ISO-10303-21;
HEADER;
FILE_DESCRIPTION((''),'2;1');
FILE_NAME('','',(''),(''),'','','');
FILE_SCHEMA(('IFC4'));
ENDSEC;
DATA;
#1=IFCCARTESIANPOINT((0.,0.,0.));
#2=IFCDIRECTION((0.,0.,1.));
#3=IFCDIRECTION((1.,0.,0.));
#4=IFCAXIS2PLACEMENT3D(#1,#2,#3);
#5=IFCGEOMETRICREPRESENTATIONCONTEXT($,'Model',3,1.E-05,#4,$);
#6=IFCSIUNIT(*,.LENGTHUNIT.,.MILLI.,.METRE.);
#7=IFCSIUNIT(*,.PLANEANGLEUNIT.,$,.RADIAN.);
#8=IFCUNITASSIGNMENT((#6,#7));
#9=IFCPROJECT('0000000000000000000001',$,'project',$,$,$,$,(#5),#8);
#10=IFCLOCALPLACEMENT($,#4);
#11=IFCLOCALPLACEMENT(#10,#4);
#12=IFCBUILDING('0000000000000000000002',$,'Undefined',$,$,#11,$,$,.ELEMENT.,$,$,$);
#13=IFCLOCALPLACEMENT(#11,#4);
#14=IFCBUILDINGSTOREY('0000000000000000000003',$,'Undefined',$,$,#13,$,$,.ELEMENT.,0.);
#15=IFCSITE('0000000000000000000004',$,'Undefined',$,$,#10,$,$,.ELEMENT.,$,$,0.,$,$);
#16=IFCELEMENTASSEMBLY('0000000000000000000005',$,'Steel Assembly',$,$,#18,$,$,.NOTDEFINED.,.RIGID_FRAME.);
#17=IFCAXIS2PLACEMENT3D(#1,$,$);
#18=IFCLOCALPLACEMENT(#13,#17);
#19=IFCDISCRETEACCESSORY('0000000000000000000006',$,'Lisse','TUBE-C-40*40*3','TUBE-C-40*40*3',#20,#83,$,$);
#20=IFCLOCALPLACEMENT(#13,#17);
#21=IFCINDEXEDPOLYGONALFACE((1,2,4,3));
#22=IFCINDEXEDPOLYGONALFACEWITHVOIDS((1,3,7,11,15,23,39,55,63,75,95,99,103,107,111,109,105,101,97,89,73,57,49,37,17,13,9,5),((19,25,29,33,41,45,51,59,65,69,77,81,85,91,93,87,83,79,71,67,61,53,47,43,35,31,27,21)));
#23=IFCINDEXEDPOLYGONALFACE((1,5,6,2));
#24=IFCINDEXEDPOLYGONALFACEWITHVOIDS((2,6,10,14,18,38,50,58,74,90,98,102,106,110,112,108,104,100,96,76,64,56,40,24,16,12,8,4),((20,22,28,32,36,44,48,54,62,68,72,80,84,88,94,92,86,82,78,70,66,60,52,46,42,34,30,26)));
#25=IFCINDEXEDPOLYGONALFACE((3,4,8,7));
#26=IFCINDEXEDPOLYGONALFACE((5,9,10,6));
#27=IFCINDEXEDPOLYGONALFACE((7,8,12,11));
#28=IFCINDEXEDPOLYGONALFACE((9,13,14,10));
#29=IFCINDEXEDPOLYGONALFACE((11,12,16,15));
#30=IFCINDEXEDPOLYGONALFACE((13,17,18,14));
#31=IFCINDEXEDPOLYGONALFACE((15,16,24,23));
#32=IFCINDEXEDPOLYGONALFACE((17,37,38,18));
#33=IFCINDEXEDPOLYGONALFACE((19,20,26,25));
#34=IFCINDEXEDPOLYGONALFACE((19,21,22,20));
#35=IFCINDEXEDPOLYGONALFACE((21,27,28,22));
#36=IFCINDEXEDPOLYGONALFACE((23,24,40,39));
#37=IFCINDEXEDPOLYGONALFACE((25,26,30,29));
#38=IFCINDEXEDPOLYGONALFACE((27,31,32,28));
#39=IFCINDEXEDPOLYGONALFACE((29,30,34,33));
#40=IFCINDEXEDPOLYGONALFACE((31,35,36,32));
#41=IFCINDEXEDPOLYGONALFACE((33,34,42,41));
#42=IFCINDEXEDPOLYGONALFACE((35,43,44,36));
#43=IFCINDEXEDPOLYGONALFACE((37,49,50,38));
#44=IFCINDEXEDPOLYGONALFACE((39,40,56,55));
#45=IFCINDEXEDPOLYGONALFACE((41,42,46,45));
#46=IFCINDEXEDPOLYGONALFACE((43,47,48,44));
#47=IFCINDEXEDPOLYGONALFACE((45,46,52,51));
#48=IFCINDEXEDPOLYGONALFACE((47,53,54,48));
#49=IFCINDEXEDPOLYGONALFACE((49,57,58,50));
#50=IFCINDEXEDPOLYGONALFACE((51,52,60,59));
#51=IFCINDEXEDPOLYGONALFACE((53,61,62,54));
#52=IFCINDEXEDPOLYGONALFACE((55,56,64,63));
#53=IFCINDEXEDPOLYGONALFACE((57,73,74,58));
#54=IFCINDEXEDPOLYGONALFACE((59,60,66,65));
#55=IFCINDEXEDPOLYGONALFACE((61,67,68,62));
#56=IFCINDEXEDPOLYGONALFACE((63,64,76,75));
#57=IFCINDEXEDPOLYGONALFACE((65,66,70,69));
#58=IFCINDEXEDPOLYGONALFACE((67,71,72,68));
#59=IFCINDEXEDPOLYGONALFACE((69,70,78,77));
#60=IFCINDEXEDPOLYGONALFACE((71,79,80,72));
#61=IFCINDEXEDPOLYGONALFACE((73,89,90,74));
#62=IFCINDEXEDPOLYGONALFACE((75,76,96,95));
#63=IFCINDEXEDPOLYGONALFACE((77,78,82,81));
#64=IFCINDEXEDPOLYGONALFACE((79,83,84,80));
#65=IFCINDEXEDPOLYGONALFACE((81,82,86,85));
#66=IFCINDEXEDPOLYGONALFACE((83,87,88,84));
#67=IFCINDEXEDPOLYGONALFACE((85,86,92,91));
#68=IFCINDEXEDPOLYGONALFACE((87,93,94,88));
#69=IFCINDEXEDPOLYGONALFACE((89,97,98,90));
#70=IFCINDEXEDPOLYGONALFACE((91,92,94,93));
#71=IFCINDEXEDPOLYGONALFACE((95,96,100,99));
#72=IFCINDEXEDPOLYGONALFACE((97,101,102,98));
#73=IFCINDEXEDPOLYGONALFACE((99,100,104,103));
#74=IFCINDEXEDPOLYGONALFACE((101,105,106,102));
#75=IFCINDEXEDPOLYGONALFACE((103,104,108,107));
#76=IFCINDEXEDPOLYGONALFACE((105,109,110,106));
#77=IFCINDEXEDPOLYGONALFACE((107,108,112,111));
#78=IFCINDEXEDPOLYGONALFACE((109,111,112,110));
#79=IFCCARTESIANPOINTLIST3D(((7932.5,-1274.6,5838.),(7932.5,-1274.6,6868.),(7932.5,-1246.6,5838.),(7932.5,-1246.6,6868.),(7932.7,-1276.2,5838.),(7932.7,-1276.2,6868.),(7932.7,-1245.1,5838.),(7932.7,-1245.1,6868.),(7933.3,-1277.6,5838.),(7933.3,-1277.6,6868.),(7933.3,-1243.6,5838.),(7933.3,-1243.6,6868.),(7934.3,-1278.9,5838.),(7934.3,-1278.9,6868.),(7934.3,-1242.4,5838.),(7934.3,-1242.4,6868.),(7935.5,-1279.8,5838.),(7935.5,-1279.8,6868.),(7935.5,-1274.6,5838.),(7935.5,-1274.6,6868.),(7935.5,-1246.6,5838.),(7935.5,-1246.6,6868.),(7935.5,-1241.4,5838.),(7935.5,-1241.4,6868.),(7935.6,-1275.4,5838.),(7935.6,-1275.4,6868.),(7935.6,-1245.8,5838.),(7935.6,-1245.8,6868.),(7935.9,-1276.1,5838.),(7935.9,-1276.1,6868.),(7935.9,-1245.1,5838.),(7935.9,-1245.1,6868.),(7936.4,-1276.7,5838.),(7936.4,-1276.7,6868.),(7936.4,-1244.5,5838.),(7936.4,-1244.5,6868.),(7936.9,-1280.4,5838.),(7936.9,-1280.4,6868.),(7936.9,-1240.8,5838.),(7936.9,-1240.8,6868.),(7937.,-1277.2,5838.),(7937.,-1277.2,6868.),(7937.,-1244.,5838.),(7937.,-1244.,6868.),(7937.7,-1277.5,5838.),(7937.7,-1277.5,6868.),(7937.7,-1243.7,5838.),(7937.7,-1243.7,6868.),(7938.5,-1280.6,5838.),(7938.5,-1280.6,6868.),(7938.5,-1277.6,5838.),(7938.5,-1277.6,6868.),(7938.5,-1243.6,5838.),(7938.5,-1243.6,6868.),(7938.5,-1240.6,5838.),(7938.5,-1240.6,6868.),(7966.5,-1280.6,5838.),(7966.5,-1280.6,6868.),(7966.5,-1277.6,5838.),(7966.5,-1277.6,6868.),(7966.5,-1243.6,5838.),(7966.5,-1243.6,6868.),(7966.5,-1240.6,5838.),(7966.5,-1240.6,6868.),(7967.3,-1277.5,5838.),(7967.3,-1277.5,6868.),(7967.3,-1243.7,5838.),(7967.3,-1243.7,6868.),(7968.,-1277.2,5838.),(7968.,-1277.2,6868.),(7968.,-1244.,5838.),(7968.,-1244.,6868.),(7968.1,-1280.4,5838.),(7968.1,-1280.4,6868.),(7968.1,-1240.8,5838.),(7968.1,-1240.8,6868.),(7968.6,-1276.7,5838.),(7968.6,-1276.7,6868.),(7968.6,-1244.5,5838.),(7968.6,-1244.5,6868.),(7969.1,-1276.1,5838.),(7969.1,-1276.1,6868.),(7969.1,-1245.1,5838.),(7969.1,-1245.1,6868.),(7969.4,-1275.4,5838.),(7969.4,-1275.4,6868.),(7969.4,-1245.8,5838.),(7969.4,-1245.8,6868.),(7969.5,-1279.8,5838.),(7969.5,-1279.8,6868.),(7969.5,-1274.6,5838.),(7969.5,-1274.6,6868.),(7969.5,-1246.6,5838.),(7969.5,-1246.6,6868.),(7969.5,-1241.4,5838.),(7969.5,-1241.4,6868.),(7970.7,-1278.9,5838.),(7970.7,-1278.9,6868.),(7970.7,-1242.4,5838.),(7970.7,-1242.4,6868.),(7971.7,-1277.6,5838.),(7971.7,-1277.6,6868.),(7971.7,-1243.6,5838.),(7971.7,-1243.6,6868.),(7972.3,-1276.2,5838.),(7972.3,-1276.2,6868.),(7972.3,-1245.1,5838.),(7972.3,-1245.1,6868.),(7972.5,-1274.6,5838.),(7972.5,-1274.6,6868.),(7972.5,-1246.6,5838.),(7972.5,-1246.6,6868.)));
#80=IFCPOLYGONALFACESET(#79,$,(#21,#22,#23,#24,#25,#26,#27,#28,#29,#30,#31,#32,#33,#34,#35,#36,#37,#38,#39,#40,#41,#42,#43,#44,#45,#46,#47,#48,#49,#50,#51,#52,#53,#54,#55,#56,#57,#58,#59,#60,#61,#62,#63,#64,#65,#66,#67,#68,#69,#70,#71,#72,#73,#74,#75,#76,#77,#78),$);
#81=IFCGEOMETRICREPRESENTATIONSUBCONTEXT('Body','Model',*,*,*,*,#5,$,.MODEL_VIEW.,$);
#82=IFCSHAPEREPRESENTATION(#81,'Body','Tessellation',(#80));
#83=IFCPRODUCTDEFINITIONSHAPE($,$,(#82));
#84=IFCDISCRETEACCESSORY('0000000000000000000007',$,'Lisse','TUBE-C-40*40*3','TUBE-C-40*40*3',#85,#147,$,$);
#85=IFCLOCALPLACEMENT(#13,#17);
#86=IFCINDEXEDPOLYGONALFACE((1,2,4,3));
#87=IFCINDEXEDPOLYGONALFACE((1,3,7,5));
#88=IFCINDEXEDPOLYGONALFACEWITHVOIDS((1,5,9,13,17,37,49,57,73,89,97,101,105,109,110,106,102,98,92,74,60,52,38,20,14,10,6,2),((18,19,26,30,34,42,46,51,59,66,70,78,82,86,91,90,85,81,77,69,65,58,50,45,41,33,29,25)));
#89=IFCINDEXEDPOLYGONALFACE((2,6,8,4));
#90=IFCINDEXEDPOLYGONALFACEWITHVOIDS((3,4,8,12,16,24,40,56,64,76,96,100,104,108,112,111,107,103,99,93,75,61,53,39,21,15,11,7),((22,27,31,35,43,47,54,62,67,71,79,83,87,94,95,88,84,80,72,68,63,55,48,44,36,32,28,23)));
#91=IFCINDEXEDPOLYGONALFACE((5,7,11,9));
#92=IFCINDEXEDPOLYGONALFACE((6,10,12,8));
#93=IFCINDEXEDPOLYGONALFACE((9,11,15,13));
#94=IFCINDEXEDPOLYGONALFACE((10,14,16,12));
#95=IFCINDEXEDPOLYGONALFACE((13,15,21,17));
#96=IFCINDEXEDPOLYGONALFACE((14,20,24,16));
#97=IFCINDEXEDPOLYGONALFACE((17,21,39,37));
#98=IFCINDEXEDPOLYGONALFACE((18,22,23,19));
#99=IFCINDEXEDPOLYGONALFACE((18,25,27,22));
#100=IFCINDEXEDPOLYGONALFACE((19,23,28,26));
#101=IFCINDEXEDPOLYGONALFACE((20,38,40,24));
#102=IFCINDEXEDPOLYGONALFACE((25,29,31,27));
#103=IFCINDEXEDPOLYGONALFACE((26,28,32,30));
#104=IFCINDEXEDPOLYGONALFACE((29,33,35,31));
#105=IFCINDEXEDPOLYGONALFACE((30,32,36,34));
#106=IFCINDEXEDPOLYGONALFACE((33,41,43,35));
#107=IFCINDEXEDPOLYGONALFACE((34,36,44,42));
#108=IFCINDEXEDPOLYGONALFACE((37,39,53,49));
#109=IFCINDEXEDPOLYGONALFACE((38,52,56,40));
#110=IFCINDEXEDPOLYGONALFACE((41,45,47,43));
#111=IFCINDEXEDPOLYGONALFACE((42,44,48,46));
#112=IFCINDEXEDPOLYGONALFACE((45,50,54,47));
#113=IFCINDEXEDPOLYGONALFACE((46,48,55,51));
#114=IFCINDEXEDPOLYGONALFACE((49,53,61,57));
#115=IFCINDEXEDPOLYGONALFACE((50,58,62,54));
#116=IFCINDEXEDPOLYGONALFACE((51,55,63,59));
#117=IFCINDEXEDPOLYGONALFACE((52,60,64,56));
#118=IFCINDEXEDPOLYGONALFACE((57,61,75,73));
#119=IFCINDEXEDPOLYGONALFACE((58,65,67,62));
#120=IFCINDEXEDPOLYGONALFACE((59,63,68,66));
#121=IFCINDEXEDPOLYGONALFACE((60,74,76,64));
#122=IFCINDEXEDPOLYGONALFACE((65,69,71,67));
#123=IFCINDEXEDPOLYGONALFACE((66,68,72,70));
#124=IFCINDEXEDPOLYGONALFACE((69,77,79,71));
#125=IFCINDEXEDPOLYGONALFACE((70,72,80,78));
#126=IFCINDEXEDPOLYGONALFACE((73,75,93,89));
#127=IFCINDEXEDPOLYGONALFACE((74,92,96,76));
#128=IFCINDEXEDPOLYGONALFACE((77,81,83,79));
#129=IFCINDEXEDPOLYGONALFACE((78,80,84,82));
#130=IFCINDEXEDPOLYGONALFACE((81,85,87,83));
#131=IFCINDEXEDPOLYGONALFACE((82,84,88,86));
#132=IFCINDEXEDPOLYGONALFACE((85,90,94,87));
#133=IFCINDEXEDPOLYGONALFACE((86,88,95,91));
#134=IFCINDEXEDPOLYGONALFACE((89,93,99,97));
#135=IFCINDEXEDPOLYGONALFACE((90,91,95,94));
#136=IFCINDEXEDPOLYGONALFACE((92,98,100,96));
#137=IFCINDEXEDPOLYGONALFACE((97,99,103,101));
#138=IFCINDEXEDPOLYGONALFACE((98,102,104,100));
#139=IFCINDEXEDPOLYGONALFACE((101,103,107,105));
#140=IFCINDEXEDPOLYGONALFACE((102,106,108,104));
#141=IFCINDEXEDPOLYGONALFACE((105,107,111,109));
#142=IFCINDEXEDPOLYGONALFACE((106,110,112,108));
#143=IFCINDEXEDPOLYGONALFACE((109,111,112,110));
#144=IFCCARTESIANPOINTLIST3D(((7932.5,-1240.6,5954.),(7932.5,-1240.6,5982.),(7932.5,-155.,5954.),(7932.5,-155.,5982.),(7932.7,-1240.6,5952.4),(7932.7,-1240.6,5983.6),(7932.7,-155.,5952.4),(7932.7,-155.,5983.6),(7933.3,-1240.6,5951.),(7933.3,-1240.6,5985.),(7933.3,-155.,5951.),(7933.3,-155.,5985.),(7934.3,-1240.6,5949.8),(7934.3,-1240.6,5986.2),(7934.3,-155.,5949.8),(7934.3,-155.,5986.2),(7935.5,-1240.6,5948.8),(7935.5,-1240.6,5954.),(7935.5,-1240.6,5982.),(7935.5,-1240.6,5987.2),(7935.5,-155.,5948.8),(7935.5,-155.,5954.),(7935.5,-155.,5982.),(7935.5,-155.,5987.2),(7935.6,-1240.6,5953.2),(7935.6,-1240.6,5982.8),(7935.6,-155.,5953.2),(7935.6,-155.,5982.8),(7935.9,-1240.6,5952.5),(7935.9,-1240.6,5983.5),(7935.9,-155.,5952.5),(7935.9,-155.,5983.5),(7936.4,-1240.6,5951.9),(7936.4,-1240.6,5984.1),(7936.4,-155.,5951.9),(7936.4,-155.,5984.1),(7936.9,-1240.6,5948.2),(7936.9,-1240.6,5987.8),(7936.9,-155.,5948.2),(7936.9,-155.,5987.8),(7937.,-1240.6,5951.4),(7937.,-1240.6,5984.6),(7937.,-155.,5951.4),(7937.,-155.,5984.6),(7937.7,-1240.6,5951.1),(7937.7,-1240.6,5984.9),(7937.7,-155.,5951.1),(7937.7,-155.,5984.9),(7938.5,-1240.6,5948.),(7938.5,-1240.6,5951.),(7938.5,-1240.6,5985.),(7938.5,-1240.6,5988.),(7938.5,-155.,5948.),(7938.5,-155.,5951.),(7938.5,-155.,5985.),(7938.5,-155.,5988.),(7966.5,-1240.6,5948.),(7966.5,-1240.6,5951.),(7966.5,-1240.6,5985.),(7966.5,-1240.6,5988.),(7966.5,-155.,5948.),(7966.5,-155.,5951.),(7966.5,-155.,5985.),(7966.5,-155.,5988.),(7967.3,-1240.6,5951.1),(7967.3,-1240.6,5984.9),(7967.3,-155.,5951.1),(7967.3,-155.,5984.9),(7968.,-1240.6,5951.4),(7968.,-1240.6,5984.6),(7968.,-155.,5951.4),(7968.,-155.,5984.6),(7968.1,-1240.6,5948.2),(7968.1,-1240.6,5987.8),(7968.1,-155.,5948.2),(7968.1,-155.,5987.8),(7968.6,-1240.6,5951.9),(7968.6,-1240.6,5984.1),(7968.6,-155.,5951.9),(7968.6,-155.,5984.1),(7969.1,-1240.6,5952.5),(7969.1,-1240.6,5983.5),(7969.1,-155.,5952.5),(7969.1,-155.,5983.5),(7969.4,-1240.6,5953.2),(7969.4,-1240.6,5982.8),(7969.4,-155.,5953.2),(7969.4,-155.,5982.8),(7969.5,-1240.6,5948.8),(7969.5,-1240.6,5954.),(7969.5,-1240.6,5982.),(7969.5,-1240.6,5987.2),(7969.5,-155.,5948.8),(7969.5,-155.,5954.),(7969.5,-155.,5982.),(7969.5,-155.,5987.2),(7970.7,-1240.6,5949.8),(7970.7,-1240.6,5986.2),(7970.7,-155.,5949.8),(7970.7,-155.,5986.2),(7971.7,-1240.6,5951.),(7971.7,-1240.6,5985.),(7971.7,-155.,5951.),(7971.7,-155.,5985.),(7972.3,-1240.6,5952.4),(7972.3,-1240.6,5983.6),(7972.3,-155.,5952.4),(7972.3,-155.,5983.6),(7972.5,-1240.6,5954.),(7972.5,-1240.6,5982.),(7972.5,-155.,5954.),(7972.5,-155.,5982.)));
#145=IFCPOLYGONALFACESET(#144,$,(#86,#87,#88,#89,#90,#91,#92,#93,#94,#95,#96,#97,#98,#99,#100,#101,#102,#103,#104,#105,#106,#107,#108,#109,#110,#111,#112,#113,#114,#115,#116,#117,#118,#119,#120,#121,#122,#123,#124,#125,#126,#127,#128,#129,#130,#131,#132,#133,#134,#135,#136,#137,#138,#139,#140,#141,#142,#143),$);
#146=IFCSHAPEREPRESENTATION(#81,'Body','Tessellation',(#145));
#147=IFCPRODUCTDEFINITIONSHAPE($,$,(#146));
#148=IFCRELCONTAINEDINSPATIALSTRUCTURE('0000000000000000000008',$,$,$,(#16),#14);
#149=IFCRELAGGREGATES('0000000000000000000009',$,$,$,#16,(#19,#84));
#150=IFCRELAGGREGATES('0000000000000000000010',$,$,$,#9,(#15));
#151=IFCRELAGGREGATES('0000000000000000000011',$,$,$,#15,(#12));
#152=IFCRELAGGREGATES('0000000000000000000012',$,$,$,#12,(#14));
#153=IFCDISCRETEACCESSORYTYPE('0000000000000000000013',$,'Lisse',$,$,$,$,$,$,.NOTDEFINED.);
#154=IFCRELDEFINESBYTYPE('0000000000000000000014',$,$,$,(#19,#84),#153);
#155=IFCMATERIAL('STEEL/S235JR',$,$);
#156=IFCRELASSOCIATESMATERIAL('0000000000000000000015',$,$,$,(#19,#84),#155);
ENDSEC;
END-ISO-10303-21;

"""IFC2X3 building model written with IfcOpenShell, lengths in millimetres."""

from ifc_helpers import new_model, si_unit, frame, origin_with_axes, origin_2d_with_axis, place, context, subcontext, project, spatial, hollow_rectangle, extrude, material, type_object, element, aggregate, save


model = new_model("IFC2X3")

# Units and contexts
model_context = context("Model", 3, precision=1e-05, world=origin_with_axes())
body_context = subcontext(model_context, "Body", "Model", "MODEL_VIEW")
ifc_project = project(units=[si_unit("LENGTHUNIT", "METRE", prefix="MILLI"), si_unit("PLANEANGLEUNIT", "RADIAN")], contexts=[model_context])

# Site, building, storey
site_placement = place(None, origin_with_axes())
site = spatial("IfcSite", under=ifc_project, at=site_placement, Name="Undefined", CompositionType="ELEMENT", RefElevation=0.0)
building_placement = place(site_placement, origin_with_axes())
building = spatial("IfcBuilding", under=site, at=building_placement, Name="Undefined", CompositionType="ELEMENT")
storey_placement = place(building_placement, origin_with_axes())
storey = spatial("IfcBuildingStorey", under=building, at=storey_placement, Name="Undefined", CompositionType="ELEMENT", Elevation=0.0)

# Element assembly
assembly_1_placement = place(storey_placement, origin_with_axes())
assembly_1 = element("IfcElementAssembly", 1, at=assembly_1_placement, inside=storey, Name="Steel Assembly", AssemblyPlace="NOTDEFINED", PredefinedType="RIGID_FRAME")
ifc_material_1 = material(Name="STEEL/S235JR")

# Discrete accessories
discrete_accessory_type_1 = type_object("IfcDiscreteAccessoryType", Name="Lisse")
discrete_accessory_1_placement = place(assembly_1_placement, frame((7952.5, -1260.6, 6868.0), z_axis=(0.0, 1.0, 0.0), x_axis=(0.0, 0.0, -1.0)))
discrete_accessory_1 = element("IfcDiscreteAccessory", 2, at=discrete_accessory_1_placement, type_object=discrete_accessory_type_1, material=ifc_material_1, Name="Lisse", Description="TUBE-C-40*40*3", ObjectType="TUBE-C-40*40*3", context=body_context, shape_type="SweptSolid", body=[
    extrude(hollow_rectangle(XDim=40.0, YDim=40.0, WallThickness=3.0, InnerFilletRadius=3.0, OuterFilletRadius=6.0, at=origin_2d_with_axis()), frame((1030.0, 0.0, 0.0), z_axis=(-1.0, 0.0, 0.0), x_axis=(0.0, -1.0, 0.0)), (0.0, 0.0, 1.0), 1030.0),
])
discrete_accessory_2_placement = place(assembly_1_placement, frame((7952.5, -155.0, 5968.0), z_axis=(-1.0, 0.0, 0.0), x_axis=(0.0, -1.0, 0.0)))
discrete_accessory_2 = element("IfcDiscreteAccessory", 3, at=discrete_accessory_2_placement, type_object=discrete_accessory_type_1, material=ifc_material_1, Name="Lisse", Description="TUBE-C-40*40*3", ObjectType="TUBE-C-40*40*3", context=body_context, shape_type="SweptSolid", body=[
    extrude(hollow_rectangle(XDim=40.0, YDim=40.0, WallThickness=3.0, InnerFilletRadius=3.0, OuterFilletRadius=6.0, at=origin_2d_with_axis()), frame((1085.6, 0.0, 0.0), z_axis=(-1.0, 0.0, 0.0), x_axis=(0.0, -1.0, 0.0)), (0.0, 0.0, 1.0), 1085.6),
])
aggregate(assembly_1, [discrete_accessory_1, discrete_accessory_2])

save(model, "model.ifc")
